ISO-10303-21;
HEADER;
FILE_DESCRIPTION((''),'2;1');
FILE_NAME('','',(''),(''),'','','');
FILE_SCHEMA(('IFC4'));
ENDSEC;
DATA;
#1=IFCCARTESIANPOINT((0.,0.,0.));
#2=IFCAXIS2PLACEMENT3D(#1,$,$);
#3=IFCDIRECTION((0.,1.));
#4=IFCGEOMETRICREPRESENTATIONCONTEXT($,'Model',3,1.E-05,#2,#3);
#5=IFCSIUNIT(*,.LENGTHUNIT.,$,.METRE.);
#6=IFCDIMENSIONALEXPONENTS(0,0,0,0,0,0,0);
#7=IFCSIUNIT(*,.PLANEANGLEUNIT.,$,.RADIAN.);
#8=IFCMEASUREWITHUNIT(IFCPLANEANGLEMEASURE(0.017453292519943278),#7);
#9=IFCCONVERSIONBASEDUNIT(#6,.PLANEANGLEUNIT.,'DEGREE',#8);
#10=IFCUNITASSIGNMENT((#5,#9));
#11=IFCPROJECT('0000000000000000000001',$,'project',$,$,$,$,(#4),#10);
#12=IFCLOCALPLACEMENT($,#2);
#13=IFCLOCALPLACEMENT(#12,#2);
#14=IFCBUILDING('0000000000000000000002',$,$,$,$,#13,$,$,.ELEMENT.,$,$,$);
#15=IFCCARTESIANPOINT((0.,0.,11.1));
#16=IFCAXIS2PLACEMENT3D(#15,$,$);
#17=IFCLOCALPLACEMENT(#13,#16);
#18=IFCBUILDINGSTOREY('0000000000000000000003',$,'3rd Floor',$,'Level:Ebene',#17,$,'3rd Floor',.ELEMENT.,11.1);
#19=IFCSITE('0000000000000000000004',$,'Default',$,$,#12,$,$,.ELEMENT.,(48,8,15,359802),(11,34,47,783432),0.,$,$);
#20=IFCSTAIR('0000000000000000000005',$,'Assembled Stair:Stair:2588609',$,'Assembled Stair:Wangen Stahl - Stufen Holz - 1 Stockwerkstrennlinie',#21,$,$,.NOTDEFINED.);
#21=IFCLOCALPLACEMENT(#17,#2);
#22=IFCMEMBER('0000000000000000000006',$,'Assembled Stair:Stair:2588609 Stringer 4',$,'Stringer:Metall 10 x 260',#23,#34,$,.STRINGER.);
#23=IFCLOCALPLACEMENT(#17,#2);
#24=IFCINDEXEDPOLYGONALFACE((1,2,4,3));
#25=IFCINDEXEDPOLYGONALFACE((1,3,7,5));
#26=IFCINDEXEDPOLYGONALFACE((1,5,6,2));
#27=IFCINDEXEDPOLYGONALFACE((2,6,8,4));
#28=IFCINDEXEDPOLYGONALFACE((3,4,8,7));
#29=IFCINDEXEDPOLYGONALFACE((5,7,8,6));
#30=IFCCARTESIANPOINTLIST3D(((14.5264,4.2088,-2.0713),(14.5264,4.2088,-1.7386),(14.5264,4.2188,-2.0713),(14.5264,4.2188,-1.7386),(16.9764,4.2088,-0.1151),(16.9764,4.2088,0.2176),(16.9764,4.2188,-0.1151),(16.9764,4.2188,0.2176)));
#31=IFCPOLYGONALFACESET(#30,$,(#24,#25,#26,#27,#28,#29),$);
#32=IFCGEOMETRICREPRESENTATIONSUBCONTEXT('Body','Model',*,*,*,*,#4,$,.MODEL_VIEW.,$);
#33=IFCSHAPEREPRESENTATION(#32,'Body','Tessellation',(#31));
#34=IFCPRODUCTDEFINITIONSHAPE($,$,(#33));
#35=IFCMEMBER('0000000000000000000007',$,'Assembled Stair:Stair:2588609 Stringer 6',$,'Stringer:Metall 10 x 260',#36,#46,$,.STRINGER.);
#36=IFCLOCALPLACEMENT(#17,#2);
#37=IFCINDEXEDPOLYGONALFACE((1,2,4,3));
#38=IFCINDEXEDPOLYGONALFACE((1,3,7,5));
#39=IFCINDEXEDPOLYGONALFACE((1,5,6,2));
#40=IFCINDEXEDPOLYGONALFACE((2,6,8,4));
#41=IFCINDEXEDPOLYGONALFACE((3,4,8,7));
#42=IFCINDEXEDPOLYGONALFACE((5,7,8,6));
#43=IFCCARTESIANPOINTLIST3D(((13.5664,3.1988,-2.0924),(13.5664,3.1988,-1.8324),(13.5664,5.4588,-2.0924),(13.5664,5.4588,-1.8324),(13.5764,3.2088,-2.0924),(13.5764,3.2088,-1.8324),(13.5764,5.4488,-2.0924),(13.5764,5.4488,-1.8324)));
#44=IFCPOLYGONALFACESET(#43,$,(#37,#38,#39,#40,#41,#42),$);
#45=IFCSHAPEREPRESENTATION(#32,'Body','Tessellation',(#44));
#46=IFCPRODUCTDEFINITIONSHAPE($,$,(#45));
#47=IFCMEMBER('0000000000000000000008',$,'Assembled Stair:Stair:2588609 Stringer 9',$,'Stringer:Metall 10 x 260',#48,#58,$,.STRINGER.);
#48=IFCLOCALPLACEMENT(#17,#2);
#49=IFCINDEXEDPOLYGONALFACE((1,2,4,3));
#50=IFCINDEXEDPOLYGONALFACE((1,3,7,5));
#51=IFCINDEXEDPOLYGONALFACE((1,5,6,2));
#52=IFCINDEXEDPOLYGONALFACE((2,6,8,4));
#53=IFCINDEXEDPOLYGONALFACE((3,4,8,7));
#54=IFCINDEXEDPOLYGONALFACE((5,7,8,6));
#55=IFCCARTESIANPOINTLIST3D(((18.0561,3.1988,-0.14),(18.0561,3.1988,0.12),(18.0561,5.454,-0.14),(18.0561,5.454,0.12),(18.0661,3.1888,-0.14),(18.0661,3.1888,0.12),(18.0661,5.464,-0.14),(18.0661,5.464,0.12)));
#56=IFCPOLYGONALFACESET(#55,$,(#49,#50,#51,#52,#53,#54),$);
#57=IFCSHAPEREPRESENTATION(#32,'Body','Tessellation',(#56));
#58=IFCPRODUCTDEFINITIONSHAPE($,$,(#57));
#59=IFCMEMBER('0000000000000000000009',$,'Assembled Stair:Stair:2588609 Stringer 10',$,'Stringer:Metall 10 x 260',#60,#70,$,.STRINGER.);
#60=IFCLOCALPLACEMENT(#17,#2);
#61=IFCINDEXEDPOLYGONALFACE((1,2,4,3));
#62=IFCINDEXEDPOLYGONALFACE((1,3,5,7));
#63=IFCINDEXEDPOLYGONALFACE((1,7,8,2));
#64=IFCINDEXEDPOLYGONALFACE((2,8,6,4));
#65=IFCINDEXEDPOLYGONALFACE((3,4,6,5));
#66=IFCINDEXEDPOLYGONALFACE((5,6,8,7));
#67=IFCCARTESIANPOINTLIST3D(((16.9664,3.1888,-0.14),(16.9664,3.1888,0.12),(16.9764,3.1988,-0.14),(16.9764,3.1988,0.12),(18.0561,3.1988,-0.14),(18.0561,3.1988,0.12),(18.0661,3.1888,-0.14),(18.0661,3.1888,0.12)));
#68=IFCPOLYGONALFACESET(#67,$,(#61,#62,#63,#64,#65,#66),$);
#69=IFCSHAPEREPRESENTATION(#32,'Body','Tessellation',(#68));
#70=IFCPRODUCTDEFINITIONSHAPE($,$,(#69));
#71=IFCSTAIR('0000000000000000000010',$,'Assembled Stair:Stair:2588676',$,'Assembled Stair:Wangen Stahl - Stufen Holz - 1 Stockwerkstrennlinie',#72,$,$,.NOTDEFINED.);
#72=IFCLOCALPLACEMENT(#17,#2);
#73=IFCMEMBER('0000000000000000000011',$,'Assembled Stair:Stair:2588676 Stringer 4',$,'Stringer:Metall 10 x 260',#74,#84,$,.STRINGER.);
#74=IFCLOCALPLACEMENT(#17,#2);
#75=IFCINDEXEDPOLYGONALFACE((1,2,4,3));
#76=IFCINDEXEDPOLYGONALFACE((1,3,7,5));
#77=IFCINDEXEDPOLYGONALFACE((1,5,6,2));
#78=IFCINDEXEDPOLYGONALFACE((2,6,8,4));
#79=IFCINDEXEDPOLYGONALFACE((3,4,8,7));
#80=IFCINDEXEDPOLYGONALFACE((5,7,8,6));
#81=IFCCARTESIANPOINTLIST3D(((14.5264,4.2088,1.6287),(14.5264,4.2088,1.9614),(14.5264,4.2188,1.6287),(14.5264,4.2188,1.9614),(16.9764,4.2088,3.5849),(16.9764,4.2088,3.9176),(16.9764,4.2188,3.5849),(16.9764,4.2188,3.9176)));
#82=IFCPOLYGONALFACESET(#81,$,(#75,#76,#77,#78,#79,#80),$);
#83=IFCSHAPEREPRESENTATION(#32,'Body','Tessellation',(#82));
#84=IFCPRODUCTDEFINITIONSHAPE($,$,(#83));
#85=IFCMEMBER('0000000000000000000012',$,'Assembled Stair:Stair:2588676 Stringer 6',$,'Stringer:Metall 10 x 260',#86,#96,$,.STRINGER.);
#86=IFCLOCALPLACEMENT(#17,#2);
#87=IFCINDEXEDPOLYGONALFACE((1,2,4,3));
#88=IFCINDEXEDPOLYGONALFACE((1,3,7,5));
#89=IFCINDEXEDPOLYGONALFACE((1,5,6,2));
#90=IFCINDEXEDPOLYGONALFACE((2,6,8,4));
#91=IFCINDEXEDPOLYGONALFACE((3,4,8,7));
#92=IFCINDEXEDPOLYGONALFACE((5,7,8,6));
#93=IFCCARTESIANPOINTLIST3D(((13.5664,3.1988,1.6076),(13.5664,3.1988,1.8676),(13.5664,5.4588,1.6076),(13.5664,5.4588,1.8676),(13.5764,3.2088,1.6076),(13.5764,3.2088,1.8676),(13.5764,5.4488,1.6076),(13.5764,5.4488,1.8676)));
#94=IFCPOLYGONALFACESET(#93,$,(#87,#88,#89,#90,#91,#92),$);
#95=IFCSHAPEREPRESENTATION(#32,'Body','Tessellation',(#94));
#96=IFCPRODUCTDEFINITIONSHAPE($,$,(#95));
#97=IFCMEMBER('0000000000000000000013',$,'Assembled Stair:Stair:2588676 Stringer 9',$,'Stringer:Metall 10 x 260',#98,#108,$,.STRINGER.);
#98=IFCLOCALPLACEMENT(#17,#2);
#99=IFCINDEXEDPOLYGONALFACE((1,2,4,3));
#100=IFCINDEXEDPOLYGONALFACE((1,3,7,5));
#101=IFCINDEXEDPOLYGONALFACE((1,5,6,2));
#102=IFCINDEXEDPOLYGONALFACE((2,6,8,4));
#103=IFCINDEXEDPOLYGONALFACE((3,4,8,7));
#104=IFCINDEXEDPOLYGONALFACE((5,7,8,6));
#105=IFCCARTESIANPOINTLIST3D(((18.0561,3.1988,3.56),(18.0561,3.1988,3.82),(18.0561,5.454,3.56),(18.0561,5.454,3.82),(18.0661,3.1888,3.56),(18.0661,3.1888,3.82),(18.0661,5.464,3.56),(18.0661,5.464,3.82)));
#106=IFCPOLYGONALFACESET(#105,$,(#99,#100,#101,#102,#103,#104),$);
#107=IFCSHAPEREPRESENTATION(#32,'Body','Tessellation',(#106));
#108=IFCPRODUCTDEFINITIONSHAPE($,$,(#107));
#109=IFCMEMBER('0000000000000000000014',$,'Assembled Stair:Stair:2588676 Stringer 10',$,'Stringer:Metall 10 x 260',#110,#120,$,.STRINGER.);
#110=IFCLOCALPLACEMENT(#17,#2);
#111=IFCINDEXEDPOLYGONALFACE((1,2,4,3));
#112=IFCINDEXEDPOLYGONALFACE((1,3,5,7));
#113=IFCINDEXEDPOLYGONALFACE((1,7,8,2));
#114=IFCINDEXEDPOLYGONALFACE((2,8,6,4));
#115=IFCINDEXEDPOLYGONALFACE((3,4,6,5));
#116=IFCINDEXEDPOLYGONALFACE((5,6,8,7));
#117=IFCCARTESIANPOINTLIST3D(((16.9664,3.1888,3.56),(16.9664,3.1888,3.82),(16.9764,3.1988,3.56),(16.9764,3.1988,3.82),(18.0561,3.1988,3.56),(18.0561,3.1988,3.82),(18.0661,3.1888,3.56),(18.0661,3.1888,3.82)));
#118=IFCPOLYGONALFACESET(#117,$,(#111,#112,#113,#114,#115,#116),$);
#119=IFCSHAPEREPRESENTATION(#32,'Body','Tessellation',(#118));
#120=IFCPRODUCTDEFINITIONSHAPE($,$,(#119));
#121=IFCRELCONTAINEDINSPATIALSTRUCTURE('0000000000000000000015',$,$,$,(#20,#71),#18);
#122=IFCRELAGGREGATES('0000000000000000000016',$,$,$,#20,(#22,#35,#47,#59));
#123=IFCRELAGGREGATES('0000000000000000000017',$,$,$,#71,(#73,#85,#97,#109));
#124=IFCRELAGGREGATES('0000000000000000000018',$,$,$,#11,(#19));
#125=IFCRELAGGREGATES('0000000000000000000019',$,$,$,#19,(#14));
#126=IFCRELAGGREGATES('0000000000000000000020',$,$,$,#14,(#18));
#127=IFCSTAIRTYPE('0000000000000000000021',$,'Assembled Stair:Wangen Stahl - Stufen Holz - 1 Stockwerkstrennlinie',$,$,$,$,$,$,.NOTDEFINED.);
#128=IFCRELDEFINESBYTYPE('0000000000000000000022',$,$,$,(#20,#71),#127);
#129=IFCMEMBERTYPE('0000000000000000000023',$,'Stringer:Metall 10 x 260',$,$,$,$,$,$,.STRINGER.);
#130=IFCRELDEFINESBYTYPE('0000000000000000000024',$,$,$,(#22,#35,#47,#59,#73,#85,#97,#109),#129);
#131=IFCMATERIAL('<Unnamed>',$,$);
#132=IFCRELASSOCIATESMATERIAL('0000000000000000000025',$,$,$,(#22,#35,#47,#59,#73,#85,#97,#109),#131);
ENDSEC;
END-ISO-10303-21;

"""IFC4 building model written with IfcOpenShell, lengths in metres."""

from ifc_helpers import new_model, entity, si_unit, converted_unit, direction, frame, origin, place, context, subcontext, project, spatial, indexed_curve, outline, extrude, material, type_object, element, aggregate, save


model = new_model("IFC4")

# Units and contexts
model_context = context("Model", 3, precision=1e-05, world=origin(), true_north=direction((0.0, 1.0)))
body_context = subcontext(model_context, "Body", "Model", "MODEL_VIEW")
ifc_project = project(units=[si_unit("LENGTHUNIT", "METRE"), converted_unit("PLANEANGLEUNIT", "DEGREE", entity("IfcPlaneAngleMeasure", 0.017453292519943278), si_unit("PLANEANGLEUNIT", "RADIAN"), dimensions=[0, 0, 0, 0, 0, 0, 0])], contexts=[model_context])

# Site, building, storey
site_placement = place(None, origin())
site = spatial("IfcSite", under=ifc_project, at=site_placement, Name="Default", CompositionType="ELEMENT", RefLatitude=(48, 8, 15, 359802), RefLongitude=(11, 34, 47, 783432), RefElevation=0.0)
building_placement = place(site_placement, origin())
building = spatial("IfcBuilding", under=site, at=building_placement, CompositionType="ELEMENT")
storey_placement = place(building_placement, frame((0.0, 0.0, 11.1)))
storey = spatial("IfcBuildingStorey", under=building, at=storey_placement, Name="3rd Floor", ObjectType="Level:Ebene", LongName="3rd Floor", CompositionType="ELEMENT", Elevation=11.1)

# Stairs, members
stair_type = type_object("IfcStairType", Name="Assembled Stair:Wangen Stahl - Stufen Holz - 1 Stockwerkstrennlinie", PredefinedType="NOTDEFINED")
stair_1_placement = place(storey_placement, origin())
stair_1 = element("IfcStair", 1, at=stair_1_placement, inside=storey, type_object=stair_type, Name="Assembled Stair:Stair:2588609", ObjectType="Assembled Stair:Wangen Stahl - Stufen Holz - 1 Stockwerkstrennlinie", PredefinedType="NOTDEFINED")
ifc_material_1 = material(Name="<Unnamed>")
member_type_1 = type_object("IfcMemberType", Name="Stringer:Metall 10 x 260", PredefinedType="STRINGER")
member_1_placement = place(stair_1_placement, origin())
member_1 = element("IfcMember", 2, at=member_1_placement, type_object=member_type_1, material=ifc_material_1, Name="Assembled Stair:Stair:2588609 Stringer 4", ObjectType="Stringer:Metall 10 x 260", PredefinedType="STRINGER", context=body_context, shape_type="SweptSolid", body=[
    extrude(outline(indexed_curve([(-1.4638, -0.13), (1.6714, -0.13), (1.4638, 0.13), (-1.6714, 0.13), (-1.4638, -0.13)], self_intersect=False)), frame((15.7514, 4.2088, -0.9269), z_axis=(0.0, 1.0, 0.0), x_axis=(0.781462, 0.0, 0.623952)), (0.0, 0.0, 1.0), 0.01),
])
member_2_placement = place(stair_1_placement, origin())
member_2 = element("IfcMember", 3, at=member_2_placement, type_object=member_type_1, material=ifc_material_1, Name="Assembled Stair:Stair:2588609 Stringer 6", ObjectType="Stringer:Metall 10 x 260", PredefinedType="STRINGER", context=body_context, shape_type="SweptSolid", body=[
    extrude(outline(indexed_curve([(-1.13, -0.005), (1.13, -0.005), (1.12, 0.005), (-1.12, 0.005), (-1.13, -0.005)], self_intersect=False)), frame((13.5714, 4.3288, -2.0924), z_axis=(0.0, 0.0, 1.0), x_axis=(0.0, -1.0, 0.0)), (0.0, 0.0, 1.0), 0.26),
])
member_3_placement = place(stair_1_placement, origin())
member_3 = element("IfcMember", 4, at=member_3_placement, type_object=member_type_1, material=ifc_material_1, Name="Assembled Stair:Stair:2588609 Stringer 9", ObjectType="Stringer:Metall 10 x 260", PredefinedType="STRINGER", context=body_context, shape_type="SweptSolid", body=[
    extrude(outline(indexed_curve([(-1.1376, -0.005), (1.1376, -0.005), (1.1276, 0.005), (-1.1276, 0.005), (-1.1376, -0.005)], self_intersect=False)), frame((18.0611, 4.3264, -0.14), z_axis=(0.0, 0.0, 1.0), x_axis=(0.0, 1.0, 0.0)), (0.0, 0.0, 1.0), 0.26),
])
member_4_placement = place(stair_1_placement, origin())
member_4 = element("IfcMember", 5, at=member_4_placement, type_object=member_type_1, material=ifc_material_1, Name="Assembled Stair:Stair:2588609 Stringer 10", ObjectType="Stringer:Metall 10 x 260", PredefinedType="STRINGER", context=body_context, shape_type="SweptSolid", body=[
    extrude(outline(indexed_curve([(-0.5498, -0.005), (0.5498, -0.005), (0.5398, 0.005), (-0.5398, 0.005), (-0.5498, -0.005)], self_intersect=False)), frame((17.5163, 3.1938, -0.14)), (0.0, 0.0, 1.0), 0.26),
])
stair_2_placement = place(storey_placement, origin())
stair_2 = element("IfcStair", 6, at=stair_2_placement, inside=storey, type_object=stair_type, Name="Assembled Stair:Stair:2588676", ObjectType="Assembled Stair:Wangen Stahl - Stufen Holz - 1 Stockwerkstrennlinie", PredefinedType="NOTDEFINED")
member_5_placement = place(stair_2_placement, origin())
member_5 = element("IfcMember", 7, at=member_5_placement, type_object=member_type_1, material=ifc_material_1, Name="Assembled Stair:Stair:2588676 Stringer 4", ObjectType="Stringer:Metall 10 x 260", PredefinedType="STRINGER", context=body_context, shape_type="SweptSolid", body=[
    extrude(outline(indexed_curve([(-1.4638, -0.13), (1.6714, -0.13), (1.4638, 0.13), (-1.6714, 0.13), (-1.4638, -0.13)], self_intersect=False)), frame((15.7514, 4.2088, 2.7731), z_axis=(0.0, 1.0, 0.0), x_axis=(0.781462, 0.0, 0.623952)), (0.0, 0.0, 1.0), 0.01),
])
member_6_placement = place(stair_2_placement, origin())
member_6 = element("IfcMember", 8, at=member_6_placement, type_object=member_type_1, material=ifc_material_1, Name="Assembled Stair:Stair:2588676 Stringer 6", ObjectType="Stringer:Metall 10 x 260", PredefinedType="STRINGER", context=body_context, shape_type="SweptSolid", body=[
    extrude(outline(indexed_curve([(-1.13, -0.005), (1.13, -0.005), (1.12, 0.005), (-1.12, 0.005), (-1.13, -0.005)], self_intersect=False)), frame((13.5714, 4.3288, 1.6076), z_axis=(0.0, 0.0, 1.0), x_axis=(0.0, -1.0, 0.0)), (0.0, 0.0, 1.0), 0.26),
])
member_7_placement = place(stair_2_placement, origin())
member_7 = element("IfcMember", 9, at=member_7_placement, type_object=member_type_1, material=ifc_material_1, Name="Assembled Stair:Stair:2588676 Stringer 9", ObjectType="Stringer:Metall 10 x 260", PredefinedType="STRINGER", context=body_context, shape_type="SweptSolid", body=[
    extrude(outline(indexed_curve([(-1.1376, -0.005), (1.1376, -0.005), (1.1276, 0.005), (-1.1276, 0.005), (-1.1376, -0.005)], self_intersect=False)), frame((18.0611, 4.3264, 3.56), z_axis=(0.0, 0.0, 1.0), x_axis=(0.0, 1.0, 0.0)), (0.0, 0.0, 1.0), 0.26),
])
member_8_placement = place(stair_2_placement, origin())
member_8 = element("IfcMember", 10, at=member_8_placement, type_object=member_type_1, material=ifc_material_1, Name="Assembled Stair:Stair:2588676 Stringer 10", ObjectType="Stringer:Metall 10 x 260", PredefinedType="STRINGER", context=body_context, shape_type="SweptSolid", body=[
    extrude(outline(indexed_curve([(-0.5498, -0.005), (0.5498, -0.005), (0.5398, 0.005), (-0.5398, 0.005), (-0.5498, -0.005)], self_intersect=False)), frame((17.5163, 3.1938, 3.56)), (0.0, 0.0, 1.0), 0.26),
])

aggregate(stair_1, [member_1, member_2, member_3, member_4])

aggregate(stair_2, [member_5, member_6, member_7, member_8])

save(model, "model.ifc")
